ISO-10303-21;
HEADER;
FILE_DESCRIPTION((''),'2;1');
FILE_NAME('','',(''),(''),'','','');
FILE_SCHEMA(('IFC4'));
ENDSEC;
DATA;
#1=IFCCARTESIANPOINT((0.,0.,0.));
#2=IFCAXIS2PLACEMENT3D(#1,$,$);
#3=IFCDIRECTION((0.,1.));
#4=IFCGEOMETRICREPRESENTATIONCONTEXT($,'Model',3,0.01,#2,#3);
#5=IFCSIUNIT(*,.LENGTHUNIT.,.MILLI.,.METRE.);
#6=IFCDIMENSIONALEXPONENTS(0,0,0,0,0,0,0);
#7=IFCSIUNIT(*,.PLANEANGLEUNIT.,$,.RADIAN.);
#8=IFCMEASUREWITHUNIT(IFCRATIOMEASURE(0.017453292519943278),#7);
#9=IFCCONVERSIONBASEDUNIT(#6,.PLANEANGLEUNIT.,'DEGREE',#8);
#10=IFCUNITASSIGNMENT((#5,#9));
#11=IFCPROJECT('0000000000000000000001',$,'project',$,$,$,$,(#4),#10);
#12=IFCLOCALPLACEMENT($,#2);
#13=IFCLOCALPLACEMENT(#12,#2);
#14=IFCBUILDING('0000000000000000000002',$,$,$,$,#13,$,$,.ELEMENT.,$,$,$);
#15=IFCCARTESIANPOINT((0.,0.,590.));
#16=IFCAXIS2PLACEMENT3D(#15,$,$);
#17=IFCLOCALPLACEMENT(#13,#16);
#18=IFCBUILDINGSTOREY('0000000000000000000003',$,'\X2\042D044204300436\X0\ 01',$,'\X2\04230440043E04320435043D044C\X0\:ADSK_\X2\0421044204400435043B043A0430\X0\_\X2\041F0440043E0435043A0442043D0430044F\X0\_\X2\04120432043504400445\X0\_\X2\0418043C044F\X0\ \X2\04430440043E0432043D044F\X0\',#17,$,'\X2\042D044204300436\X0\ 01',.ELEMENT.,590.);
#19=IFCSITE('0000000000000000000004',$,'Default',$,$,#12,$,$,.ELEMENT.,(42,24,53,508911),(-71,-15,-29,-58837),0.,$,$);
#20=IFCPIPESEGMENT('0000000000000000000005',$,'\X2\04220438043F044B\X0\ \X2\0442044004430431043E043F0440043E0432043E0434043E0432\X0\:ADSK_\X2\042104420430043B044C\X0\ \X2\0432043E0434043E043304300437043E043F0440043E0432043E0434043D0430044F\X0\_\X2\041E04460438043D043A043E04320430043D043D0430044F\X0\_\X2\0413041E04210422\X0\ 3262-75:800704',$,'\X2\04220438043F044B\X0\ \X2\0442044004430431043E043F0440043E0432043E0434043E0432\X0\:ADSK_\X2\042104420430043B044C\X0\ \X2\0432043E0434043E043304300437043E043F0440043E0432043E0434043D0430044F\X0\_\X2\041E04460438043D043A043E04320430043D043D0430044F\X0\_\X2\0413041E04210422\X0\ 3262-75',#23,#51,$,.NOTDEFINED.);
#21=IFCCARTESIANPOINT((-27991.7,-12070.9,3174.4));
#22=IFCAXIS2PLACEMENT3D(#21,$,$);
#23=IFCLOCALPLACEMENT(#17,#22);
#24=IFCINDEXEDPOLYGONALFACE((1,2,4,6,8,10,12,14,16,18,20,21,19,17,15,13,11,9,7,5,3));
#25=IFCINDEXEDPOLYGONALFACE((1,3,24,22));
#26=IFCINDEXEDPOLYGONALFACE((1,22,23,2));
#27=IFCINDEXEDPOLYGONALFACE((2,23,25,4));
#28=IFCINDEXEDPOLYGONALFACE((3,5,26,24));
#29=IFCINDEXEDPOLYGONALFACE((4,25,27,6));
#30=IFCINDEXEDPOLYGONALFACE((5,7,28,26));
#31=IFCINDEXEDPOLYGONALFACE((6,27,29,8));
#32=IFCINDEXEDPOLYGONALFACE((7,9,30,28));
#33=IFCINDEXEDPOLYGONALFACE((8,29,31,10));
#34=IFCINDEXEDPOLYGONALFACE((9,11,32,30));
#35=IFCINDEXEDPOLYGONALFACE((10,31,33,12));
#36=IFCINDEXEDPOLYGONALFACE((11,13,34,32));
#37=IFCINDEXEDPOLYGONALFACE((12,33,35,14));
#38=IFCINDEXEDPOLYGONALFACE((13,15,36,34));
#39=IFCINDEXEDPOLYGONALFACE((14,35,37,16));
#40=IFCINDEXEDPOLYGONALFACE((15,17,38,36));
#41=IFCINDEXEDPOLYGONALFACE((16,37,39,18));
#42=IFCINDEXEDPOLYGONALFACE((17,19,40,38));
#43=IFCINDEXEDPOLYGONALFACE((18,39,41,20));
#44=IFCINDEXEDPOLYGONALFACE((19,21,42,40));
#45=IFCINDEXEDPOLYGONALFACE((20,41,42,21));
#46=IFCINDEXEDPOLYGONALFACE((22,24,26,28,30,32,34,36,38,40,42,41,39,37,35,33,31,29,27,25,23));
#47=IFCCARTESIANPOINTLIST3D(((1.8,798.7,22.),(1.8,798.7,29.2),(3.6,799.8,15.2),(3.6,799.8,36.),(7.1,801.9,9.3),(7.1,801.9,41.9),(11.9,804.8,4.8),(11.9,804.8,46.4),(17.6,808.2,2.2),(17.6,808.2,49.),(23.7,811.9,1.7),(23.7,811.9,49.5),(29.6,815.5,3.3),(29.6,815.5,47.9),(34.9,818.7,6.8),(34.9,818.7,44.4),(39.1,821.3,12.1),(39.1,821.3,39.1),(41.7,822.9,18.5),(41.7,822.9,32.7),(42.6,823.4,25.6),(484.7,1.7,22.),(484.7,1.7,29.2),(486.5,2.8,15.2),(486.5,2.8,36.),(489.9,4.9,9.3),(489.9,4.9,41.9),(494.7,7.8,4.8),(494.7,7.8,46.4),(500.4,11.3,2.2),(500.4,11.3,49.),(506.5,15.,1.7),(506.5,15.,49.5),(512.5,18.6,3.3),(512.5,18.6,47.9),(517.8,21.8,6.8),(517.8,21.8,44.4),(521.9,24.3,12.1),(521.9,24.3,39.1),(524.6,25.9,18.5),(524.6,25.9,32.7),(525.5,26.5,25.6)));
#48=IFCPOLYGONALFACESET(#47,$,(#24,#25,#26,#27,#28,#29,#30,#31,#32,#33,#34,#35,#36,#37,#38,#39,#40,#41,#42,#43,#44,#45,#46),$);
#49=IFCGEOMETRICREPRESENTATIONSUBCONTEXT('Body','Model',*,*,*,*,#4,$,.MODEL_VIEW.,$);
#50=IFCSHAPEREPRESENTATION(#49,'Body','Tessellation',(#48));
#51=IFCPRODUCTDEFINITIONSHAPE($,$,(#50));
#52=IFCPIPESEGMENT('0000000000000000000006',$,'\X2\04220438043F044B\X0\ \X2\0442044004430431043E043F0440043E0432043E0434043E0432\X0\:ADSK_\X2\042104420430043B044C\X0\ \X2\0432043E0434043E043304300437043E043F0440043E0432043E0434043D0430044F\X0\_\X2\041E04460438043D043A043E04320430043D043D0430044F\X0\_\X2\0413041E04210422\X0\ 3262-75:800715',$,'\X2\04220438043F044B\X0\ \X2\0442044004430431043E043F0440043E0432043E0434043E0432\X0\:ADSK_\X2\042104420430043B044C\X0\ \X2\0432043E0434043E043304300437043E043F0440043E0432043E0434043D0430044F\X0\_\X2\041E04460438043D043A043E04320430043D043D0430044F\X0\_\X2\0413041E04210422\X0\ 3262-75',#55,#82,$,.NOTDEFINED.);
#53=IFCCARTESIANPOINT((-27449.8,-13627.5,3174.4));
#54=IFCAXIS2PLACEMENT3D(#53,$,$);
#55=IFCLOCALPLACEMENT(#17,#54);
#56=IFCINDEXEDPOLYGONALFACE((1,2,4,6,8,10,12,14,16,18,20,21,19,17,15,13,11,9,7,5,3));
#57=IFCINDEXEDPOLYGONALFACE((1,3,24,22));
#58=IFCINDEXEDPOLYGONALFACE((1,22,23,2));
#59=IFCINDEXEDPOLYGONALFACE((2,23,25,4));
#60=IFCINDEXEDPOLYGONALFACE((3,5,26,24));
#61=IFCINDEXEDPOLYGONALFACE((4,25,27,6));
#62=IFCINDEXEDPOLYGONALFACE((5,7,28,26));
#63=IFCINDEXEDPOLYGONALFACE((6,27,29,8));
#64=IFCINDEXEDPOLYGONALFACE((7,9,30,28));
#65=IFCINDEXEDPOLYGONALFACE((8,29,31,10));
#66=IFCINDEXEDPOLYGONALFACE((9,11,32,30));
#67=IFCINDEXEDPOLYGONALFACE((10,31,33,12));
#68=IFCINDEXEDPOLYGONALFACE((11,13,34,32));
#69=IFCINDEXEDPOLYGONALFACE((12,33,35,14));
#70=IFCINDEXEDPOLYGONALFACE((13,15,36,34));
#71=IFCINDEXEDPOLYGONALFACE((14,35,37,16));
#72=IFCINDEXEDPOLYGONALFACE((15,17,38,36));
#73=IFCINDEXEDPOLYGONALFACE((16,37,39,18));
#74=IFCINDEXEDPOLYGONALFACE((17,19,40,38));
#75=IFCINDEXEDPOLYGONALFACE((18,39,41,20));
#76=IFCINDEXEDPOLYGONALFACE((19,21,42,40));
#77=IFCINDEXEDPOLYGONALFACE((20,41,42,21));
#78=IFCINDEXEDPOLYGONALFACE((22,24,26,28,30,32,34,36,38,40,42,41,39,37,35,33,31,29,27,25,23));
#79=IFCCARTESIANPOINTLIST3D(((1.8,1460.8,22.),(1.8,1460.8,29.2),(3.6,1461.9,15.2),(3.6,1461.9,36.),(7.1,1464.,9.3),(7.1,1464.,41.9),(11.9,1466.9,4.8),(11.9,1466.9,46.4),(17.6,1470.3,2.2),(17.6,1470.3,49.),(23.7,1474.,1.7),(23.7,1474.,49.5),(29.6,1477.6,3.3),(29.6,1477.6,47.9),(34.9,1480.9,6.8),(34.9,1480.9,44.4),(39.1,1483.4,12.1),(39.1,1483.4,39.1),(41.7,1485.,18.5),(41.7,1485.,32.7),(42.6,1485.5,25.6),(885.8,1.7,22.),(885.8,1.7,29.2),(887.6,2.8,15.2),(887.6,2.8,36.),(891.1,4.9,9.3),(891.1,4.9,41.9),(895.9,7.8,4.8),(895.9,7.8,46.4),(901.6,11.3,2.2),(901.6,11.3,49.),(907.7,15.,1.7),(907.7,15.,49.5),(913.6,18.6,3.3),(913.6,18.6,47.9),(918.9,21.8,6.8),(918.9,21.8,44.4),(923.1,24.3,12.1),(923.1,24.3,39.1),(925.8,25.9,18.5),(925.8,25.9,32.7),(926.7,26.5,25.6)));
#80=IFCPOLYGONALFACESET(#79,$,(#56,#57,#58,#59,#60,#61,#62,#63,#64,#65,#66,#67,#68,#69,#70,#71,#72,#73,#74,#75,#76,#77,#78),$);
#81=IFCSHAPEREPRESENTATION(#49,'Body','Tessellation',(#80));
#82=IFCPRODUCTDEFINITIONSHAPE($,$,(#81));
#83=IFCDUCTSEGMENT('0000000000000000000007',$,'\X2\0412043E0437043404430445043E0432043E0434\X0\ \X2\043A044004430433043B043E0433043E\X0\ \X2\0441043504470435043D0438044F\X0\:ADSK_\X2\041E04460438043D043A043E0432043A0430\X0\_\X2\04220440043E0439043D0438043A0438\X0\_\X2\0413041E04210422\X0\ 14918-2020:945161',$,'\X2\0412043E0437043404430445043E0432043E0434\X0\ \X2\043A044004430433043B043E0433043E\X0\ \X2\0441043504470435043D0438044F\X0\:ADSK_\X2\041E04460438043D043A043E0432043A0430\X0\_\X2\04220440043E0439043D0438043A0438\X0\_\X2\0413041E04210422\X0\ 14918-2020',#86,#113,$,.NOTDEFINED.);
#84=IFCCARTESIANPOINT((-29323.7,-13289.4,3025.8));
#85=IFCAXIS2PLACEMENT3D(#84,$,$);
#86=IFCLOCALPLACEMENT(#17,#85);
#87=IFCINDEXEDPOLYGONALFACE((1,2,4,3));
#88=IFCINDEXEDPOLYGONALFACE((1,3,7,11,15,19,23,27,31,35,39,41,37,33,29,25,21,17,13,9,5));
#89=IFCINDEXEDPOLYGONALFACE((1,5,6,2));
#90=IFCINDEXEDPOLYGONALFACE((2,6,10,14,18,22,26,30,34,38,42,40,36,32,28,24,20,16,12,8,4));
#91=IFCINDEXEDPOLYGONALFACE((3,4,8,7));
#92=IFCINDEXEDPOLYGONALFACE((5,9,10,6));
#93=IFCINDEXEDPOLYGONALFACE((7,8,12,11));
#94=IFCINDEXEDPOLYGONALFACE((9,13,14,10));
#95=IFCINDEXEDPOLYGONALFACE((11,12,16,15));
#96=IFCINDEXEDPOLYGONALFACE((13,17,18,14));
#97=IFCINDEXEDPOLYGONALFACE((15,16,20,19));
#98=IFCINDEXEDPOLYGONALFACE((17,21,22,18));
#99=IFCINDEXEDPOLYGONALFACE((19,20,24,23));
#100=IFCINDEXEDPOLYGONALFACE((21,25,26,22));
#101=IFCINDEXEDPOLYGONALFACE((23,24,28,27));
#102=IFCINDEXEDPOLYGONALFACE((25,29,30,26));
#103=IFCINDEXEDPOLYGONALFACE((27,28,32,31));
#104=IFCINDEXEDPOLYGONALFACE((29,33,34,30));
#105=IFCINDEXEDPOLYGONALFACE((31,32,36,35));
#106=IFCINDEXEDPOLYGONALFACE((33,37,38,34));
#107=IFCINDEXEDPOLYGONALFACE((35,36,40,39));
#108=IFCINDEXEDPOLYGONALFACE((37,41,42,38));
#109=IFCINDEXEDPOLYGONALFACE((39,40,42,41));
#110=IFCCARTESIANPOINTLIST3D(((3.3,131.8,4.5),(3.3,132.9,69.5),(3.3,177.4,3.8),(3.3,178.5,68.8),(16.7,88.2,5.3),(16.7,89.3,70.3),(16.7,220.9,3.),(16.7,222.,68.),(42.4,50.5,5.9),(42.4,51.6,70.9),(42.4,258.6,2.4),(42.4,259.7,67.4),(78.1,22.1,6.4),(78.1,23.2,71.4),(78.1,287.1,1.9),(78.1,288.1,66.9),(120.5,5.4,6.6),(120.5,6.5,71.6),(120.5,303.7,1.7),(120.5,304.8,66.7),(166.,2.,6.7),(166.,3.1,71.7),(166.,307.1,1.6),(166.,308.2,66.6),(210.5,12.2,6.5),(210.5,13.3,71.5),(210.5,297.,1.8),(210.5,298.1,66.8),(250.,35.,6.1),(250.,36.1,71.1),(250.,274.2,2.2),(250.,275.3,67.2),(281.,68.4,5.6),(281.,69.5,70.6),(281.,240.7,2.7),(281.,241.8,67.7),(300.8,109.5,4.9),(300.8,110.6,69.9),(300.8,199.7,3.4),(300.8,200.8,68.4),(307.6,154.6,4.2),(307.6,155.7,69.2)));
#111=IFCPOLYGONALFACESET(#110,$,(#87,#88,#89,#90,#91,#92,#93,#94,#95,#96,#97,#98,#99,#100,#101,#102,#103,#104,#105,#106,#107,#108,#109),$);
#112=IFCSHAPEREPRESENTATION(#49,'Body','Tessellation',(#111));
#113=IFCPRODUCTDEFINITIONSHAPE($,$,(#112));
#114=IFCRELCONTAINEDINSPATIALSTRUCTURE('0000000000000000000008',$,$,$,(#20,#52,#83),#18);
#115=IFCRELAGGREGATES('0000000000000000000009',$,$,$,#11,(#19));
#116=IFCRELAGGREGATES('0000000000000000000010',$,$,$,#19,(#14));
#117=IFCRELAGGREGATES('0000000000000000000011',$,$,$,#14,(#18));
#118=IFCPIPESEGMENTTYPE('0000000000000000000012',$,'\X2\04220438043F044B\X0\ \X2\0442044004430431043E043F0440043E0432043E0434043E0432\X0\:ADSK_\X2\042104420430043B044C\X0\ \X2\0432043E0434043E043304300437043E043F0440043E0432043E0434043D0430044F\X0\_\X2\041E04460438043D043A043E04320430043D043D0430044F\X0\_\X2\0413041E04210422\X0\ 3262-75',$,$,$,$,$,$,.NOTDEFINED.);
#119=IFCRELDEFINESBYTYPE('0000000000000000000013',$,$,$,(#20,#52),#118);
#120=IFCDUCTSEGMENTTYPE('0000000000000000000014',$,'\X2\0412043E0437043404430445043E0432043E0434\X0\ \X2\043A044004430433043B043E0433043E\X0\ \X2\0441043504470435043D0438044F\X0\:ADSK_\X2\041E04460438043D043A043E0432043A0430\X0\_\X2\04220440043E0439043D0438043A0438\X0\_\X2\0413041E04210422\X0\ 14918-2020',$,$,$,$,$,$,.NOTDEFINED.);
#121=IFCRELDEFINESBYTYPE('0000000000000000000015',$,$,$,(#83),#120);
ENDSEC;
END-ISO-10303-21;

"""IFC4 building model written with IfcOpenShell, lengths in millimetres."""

from ifc_helpers import new_model, entity, si_unit, converted_unit, direction, frame, frame_2d, origin, origin_2d_with_axis, place, context, subcontext, project, spatial, circle, extrude, type_object, element, save


model = new_model("IFC4")

# Units and contexts
model_context = context("Model", 3, precision=0.01, world=origin(), true_north=direction((0.0, 1.0)))
body_context = subcontext(model_context, "Body", "Model", "MODEL_VIEW")
ifc_project = project(units=[si_unit("LENGTHUNIT", "METRE", prefix="MILLI"), converted_unit("PLANEANGLEUNIT", "DEGREE", entity("IfcRatioMeasure", 0.017453292519943278), si_unit("PLANEANGLEUNIT", "RADIAN"), dimensions=[0, 0, 0, 0, 0, 0, 0])], contexts=[model_context])

# Site, building, storey
site_placement = place(None, origin())
site = spatial("IfcSite", under=ifc_project, at=site_placement, Name="Default", CompositionType="ELEMENT", RefLatitude=(42, 24, 53, 508911), RefLongitude=(-71, -15, -29, -58837), RefElevation=0.0)
building_placement = place(site_placement, origin())
building = spatial("IfcBuilding", under=site, at=building_placement, CompositionType="ELEMENT")
storey_placement = place(building_placement, frame((0.0, 0.0, 590.0)))
storey = spatial("IfcBuildingStorey", under=building, at=storey_placement, Name="Этаж 01", ObjectType="Уровень:ADSK_Стрелка_Проектная_Вверх_Имя уровня", LongName="Этаж 01", CompositionType="ELEMENT", Elevation=590.0)

# Pipe segments
pipe_segment_type = type_object("IfcPipeSegmentType", Name="Типы трубопроводов:ADSK_Сталь водогазопроводная_Оцинкованная_ГОСТ 3262-75", PredefinedType="NOTDEFINED")
pipe_segment_1_placement = place(storey_placement, frame((-27991.7, -12070.9, 3174.4)))
element("IfcPipeSegment", 1, at=pipe_segment_1_placement, inside=storey, type_object=pipe_segment_type, Name="Типы трубопроводов:ADSK_Сталь водогазопроводная_Оцинкованная_ГОСТ 3262-75:800704", ObjectType="Типы трубопроводов:ADSK_Сталь водогазопроводная_Оцинкованная_ГОСТ 3262-75", PredefinedType="NOTDEFINED", context=body_context, shape_type="SweptSolid", body=[
    extrude(circle(Radius=24.0, at=origin_2d_with_axis()), frame((505.0, 14.0, 25.6), z_axis=(-0.518188, 0.855267, 0.0), x_axis=(0.855267, 0.518188, 0.0)), (0.0, 0.0, 1.0), 931.8),
])
pipe_segment_2_placement = place(storey_placement, frame((-27449.8, -13627.5, 3174.4)))
element("IfcPipeSegment", 2, at=pipe_segment_2_placement, inside=storey, type_object=pipe_segment_type, Name="Типы трубопроводов:ADSK_Сталь водогазопроводная_Оцинкованная_ГОСТ 3262-75:800715", ObjectType="Типы трубопроводов:ADSK_Сталь водогазопроводная_Оцинкованная_ГОСТ 3262-75", PredefinedType="NOTDEFINED", context=body_context, shape_type="SweptSolid", body=[
    extrude(circle(Radius=24.0, at=origin_2d_with_axis()), frame((906.1, 14.0, 25.6), z_axis=(-0.518188, 0.855267, 0.0), x_axis=(0.855267, 0.518188, 0.0)), (0.0, 0.0, 1.0), 1706.0),
])

# Duct segment
duct_segment_type = type_object("IfcDuctSegmentType", Name="Воздуховод круглого сечения:ADSK_Оцинковка_Тройники_ГОСТ 14918-2020", PredefinedType="NOTDEFINED")
duct_segment_1_placement = place(storey_placement, frame((-29323.7, -13289.4, 3025.8)))
element("IfcDuctSegment", 3, at=duct_segment_1_placement, inside=storey, type_object=duct_segment_type, Name="Воздуховод круглого сечения:ADSK_Оцинковка_Тройники_ГОСТ 14918-2020:945161", ObjectType="Воздуховод круглого сечения:ADSK_Оцинковка_Тройники_ГОСТ 14918-2020", PredefinedType="NOTDEFINED", context=body_context, shape_type="SweptSolid", body=[
    extrude(circle(Radius=153.0, at=frame_2d((0.0, 0.0), x_axis=(1.0, 0.0))), frame((154.6, 154.6, 4.2), z_axis=(0.0, 0.016702, 0.999861), x_axis=(1.0, 0.0, 0.0)), (0.0, 0.0, 1.0), 65.0),
])

save(model, "model.ifc")
